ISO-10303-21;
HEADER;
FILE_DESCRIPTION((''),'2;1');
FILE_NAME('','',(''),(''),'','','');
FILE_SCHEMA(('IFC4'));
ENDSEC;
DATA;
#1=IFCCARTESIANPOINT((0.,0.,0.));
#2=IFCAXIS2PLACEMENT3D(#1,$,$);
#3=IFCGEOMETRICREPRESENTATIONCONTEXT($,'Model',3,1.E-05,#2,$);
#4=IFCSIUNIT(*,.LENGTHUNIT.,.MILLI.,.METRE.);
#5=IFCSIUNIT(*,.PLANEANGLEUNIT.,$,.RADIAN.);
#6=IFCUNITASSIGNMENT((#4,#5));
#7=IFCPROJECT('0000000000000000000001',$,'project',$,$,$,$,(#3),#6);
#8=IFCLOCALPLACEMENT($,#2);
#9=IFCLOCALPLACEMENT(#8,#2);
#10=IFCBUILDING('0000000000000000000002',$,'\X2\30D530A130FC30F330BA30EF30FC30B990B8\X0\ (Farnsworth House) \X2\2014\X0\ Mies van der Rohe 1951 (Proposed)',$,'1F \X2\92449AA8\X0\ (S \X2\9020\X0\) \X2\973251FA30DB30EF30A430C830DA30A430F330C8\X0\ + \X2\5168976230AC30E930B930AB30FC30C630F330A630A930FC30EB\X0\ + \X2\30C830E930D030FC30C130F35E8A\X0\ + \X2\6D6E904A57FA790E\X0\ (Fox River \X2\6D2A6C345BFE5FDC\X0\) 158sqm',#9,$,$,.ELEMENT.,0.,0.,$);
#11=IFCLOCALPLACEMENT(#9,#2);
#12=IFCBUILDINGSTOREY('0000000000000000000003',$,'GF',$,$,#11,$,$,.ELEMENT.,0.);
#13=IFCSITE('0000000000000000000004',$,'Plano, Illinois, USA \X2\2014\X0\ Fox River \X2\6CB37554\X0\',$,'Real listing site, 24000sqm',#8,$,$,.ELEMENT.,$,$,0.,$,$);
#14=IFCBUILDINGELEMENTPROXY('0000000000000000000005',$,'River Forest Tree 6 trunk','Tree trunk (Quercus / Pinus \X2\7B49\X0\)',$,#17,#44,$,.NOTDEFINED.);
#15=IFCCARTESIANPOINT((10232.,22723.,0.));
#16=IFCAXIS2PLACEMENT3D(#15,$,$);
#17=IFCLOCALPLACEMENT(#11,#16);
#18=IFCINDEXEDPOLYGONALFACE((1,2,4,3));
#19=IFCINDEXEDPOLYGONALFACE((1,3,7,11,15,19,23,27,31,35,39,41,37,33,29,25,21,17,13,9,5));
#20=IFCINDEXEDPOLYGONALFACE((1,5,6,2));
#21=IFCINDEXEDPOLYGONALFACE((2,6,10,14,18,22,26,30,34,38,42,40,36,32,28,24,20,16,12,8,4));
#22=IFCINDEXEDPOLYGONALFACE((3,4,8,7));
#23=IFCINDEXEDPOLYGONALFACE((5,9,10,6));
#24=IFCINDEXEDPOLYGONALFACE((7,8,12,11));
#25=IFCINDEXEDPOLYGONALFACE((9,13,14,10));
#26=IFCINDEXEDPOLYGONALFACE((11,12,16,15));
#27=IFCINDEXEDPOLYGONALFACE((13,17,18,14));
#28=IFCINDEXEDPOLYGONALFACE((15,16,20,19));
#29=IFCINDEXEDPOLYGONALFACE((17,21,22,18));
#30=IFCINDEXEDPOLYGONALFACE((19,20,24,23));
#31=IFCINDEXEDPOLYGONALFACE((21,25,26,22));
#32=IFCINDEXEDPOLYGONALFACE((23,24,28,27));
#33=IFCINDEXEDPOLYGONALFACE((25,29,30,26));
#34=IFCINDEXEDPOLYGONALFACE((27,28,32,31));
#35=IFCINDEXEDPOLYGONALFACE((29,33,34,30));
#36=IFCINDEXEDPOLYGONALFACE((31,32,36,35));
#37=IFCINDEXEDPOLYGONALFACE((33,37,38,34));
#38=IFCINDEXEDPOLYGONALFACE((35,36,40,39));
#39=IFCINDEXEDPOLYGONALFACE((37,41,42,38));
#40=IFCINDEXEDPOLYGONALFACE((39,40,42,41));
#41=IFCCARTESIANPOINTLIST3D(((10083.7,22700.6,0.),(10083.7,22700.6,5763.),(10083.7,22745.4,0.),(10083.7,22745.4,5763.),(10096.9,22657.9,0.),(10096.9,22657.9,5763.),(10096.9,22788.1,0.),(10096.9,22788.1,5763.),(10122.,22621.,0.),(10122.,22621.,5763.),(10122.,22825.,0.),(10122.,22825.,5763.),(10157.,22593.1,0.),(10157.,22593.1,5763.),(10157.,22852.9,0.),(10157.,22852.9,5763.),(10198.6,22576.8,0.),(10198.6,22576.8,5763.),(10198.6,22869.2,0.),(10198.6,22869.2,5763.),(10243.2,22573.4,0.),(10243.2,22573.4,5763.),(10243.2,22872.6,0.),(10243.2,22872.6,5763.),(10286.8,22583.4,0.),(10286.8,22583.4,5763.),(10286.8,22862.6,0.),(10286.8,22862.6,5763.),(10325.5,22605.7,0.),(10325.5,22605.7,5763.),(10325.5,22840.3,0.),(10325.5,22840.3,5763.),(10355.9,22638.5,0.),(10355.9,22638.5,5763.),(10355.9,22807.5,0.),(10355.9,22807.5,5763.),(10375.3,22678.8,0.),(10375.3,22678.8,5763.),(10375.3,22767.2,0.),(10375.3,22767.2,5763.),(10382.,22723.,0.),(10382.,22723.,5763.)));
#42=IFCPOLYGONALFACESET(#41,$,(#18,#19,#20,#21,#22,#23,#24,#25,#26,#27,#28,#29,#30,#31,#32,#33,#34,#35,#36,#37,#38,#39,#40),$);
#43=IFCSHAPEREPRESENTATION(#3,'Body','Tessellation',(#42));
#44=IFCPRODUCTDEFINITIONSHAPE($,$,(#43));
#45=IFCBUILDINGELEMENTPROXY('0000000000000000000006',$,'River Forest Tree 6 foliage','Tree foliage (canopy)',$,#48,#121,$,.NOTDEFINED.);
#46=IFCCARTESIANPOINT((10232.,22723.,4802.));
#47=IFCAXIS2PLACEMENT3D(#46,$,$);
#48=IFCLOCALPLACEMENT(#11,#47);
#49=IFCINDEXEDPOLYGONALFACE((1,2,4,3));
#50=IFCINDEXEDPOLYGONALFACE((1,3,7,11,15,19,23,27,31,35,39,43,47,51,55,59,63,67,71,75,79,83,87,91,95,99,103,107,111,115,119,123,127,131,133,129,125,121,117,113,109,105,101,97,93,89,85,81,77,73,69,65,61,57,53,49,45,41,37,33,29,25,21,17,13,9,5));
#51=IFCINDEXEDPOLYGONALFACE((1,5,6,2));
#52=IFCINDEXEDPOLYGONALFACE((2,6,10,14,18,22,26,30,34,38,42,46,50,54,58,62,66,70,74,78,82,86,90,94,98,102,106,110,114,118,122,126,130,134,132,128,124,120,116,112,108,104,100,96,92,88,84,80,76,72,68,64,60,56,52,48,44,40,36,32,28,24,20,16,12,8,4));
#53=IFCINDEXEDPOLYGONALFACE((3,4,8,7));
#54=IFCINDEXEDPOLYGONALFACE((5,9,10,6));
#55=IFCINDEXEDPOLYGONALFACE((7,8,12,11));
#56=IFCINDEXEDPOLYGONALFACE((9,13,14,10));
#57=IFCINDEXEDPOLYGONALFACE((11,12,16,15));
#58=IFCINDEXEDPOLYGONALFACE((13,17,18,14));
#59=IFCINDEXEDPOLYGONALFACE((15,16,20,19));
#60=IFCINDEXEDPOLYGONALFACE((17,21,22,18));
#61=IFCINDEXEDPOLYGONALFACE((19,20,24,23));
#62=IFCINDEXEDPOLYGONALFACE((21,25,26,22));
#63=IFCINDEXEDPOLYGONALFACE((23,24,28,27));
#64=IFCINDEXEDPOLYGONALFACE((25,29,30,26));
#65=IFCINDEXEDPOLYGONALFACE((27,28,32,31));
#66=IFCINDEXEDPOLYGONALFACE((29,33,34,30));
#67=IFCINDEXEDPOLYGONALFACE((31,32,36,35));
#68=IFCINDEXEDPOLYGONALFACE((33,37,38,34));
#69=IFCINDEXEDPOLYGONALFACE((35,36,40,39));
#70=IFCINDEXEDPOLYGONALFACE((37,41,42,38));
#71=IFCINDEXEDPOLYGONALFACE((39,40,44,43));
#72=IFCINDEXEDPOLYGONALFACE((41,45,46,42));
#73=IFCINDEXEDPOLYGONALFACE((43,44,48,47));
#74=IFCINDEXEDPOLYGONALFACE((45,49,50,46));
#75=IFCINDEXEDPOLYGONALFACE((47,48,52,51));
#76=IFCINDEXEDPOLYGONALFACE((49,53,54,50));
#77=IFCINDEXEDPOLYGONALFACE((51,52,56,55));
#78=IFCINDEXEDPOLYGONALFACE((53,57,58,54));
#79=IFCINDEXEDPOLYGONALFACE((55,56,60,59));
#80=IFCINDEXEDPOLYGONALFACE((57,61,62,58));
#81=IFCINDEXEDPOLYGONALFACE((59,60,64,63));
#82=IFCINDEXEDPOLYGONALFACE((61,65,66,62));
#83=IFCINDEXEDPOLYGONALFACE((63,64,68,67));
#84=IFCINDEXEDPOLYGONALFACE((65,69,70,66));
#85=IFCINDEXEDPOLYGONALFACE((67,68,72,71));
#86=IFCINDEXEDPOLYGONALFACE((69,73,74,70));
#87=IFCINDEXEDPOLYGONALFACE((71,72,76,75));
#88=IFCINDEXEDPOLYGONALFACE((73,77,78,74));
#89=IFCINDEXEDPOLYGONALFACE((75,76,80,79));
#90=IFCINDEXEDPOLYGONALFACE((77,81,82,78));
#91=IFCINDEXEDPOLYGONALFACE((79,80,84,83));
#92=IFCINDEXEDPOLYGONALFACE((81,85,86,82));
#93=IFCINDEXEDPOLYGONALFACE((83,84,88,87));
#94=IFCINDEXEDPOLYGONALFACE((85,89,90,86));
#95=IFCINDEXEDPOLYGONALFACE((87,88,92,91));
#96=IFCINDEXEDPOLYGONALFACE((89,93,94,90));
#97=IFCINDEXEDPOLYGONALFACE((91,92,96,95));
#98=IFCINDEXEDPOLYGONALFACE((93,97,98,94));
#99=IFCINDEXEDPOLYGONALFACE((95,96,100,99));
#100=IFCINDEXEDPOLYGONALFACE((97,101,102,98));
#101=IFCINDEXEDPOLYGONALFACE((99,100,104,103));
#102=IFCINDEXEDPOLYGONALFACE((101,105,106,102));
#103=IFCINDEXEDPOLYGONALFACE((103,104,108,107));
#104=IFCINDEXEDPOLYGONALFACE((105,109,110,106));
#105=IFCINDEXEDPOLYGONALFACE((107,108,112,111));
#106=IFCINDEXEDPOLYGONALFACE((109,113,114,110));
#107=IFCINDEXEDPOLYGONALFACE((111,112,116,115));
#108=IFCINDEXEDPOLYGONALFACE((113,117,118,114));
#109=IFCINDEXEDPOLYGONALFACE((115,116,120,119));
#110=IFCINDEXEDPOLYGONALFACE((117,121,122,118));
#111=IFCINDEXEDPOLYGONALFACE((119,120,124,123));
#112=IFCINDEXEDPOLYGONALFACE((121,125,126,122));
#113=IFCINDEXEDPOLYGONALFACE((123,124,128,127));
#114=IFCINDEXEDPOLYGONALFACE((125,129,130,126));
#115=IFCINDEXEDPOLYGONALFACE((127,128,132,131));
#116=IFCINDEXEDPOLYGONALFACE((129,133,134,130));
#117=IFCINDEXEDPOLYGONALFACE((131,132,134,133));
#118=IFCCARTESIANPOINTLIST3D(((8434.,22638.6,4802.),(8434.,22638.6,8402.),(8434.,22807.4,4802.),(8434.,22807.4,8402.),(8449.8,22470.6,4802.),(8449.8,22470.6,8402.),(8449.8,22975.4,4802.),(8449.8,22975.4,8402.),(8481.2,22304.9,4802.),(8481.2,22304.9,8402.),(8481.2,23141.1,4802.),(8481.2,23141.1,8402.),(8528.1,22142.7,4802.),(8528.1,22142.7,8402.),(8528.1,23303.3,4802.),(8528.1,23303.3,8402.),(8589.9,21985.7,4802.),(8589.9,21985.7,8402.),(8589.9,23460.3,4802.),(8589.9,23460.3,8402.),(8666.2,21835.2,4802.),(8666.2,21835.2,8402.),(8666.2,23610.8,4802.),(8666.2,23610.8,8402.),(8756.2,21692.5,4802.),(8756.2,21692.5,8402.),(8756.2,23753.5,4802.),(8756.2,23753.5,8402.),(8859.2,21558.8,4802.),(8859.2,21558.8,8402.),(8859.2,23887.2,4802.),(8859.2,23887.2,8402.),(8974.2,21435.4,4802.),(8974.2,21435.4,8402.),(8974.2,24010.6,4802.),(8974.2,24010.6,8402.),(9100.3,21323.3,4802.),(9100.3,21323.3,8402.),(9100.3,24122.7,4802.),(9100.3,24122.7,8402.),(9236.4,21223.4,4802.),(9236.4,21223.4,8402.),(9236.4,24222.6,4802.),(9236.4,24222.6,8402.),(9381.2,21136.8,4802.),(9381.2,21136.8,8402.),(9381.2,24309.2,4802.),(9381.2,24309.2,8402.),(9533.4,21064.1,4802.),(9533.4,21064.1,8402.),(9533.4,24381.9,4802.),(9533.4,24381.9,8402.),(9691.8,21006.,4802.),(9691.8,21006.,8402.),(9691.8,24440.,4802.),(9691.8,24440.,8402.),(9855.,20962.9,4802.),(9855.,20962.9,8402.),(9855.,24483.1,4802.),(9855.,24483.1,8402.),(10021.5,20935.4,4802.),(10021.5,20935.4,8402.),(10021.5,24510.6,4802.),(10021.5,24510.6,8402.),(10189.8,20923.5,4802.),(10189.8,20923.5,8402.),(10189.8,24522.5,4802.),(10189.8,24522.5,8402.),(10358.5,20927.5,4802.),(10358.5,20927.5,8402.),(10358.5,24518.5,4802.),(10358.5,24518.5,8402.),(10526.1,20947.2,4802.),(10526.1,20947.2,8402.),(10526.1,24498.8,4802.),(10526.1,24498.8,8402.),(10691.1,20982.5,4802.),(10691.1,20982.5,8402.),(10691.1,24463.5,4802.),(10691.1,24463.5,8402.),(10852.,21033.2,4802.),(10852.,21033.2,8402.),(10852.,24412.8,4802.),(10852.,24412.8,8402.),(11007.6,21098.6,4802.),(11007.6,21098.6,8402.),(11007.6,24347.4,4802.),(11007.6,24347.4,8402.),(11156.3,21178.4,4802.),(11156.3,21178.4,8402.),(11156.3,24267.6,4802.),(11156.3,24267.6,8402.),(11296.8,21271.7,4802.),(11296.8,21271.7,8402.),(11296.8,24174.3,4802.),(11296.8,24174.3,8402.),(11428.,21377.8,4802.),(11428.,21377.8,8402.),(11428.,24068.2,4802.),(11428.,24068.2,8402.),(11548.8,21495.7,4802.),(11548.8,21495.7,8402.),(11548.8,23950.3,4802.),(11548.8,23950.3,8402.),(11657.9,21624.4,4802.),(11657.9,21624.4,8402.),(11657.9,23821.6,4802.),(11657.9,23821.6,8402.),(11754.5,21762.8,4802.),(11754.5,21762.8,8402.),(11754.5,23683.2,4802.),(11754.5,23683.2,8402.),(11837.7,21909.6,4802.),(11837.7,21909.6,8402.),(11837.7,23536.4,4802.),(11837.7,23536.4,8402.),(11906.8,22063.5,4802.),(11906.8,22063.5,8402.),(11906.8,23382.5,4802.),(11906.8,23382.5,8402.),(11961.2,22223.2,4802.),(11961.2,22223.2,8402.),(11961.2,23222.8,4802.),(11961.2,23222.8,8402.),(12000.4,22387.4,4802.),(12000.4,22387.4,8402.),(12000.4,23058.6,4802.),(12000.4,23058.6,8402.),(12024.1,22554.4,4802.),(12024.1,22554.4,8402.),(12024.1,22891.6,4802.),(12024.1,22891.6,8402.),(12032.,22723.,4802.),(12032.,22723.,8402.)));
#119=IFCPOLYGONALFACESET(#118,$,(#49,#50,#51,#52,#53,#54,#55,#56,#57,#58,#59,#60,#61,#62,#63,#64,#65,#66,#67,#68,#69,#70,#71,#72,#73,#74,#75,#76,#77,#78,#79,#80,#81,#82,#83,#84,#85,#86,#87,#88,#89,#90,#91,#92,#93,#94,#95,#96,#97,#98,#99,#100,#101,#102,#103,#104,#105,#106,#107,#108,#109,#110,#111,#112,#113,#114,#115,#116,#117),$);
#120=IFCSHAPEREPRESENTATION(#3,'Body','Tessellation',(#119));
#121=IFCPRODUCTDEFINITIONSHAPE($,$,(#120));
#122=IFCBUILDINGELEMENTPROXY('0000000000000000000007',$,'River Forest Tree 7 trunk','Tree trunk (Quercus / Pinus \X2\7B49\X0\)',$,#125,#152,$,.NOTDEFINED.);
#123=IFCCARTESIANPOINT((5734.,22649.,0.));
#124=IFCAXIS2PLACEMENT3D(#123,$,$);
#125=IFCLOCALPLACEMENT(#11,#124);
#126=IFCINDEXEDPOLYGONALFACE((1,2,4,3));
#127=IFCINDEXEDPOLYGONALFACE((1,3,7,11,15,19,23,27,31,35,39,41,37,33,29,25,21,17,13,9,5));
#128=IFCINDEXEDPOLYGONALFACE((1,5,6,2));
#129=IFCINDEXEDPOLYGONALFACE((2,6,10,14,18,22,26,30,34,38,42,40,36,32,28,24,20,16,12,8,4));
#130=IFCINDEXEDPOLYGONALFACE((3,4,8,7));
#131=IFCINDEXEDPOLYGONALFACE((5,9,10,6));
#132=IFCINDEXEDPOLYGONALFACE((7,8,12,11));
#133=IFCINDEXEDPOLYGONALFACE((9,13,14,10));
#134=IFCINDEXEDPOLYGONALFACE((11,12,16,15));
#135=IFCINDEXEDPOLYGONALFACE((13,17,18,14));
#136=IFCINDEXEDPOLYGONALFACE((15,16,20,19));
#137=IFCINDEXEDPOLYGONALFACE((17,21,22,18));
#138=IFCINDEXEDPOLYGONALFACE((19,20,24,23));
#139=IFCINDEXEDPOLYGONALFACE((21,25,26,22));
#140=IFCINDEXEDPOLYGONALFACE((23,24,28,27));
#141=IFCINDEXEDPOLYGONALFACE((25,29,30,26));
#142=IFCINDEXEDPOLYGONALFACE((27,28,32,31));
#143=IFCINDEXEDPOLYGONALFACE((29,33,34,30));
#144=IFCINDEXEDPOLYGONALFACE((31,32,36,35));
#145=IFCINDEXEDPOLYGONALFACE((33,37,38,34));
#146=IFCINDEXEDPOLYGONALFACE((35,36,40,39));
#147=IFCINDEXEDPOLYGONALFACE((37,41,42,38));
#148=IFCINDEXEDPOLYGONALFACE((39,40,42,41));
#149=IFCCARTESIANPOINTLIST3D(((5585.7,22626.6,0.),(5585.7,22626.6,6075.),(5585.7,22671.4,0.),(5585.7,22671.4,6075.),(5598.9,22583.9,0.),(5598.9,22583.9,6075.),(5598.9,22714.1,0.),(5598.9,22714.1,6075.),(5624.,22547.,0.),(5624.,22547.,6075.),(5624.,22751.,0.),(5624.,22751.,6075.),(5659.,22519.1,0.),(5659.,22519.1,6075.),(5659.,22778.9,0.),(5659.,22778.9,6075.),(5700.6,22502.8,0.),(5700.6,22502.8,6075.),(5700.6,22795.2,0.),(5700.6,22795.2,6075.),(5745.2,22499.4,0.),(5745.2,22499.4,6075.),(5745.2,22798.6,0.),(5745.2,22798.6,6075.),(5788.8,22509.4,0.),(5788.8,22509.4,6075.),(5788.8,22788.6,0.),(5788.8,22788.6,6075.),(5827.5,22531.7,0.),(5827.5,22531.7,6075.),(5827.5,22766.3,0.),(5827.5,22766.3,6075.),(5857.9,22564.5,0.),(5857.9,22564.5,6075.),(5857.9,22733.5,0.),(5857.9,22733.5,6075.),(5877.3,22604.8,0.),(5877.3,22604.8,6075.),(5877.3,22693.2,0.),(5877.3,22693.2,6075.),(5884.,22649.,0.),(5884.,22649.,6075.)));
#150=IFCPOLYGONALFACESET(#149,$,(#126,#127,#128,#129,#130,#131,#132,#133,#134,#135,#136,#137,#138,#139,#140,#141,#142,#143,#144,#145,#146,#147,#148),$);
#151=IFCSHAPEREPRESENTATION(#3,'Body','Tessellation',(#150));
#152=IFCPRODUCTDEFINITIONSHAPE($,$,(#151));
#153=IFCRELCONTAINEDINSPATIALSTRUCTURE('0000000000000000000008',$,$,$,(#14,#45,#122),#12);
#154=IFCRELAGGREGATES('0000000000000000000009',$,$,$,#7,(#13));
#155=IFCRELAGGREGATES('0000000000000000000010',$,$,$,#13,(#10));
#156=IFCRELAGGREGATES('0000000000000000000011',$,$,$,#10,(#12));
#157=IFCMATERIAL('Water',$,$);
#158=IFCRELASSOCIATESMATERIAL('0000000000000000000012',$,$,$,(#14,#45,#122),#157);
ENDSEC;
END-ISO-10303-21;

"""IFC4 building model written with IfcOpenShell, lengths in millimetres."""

from ifc_helpers import new_model, si_unit, frame, origin, origin_2d, place, context, project, spatial, circle, extrude, material, element, save


model = new_model("IFC4")

# Units and contexts
model_context = context("Model", 3, precision=1e-05, world=origin())
ifc_project = project(units=[si_unit("LENGTHUNIT", "METRE", prefix="MILLI"), si_unit("PLANEANGLEUNIT", "RADIAN")], contexts=[model_context])

# Site, building, storey
site_placement = place(None, origin())
site = spatial("IfcSite", under=ifc_project, at=site_placement, Name="Plano, Illinois, USA — Fox River 河畔", ObjectType="Real listing site, 24000sqm", CompositionType="ELEMENT", RefElevation=0.0)
building_placement = place(site_placement, origin())
building = spatial("IfcBuilding", under=site, at=building_placement, Name="ファーンズワース邸 (Farnsworth House) — Mies van der Rohe 1951 (Proposed)", ObjectType="1F 鉄骨 (S 造) 露出ホワイトペイント + 全面ガラスカーテンウォール + トラバーチン床 + 浮遊基礎 (Fox River 洪水対応) 158sqm", CompositionType="ELEMENT", ElevationOfRefHeight=0.0, ElevationOfTerrain=0.0)
storey_placement = place(building_placement, origin())
storey = spatial("IfcBuildingStorey", under=building, at=storey_placement, Name="GF", CompositionType="ELEMENT", Elevation=0.0)

# Building element proxies
ifc_material_1 = material(Name="Water")
proxy_1_placement = place(storey_placement, frame((10232.0, 22723.0, 0.0)))
element("IfcBuildingElementProxy", 1, at=proxy_1_placement, inside=storey, material=ifc_material_1, Name="River Forest Tree 6 trunk", Description="Tree trunk (Quercus / Pinus 等)", PredefinedType="NOTDEFINED", context=model_context, shape_type="SweptSolid", body=[
    extrude(circle(Radius=150.0, at=origin_2d()), frame((10232.0, 22723.0, 0.0)), (0.0, 0.0, 1.0), 5763.0),
])
proxy_2_placement = place(storey_placement, frame((10232.0, 22723.0, 4802.0)))
element("IfcBuildingElementProxy", 2, at=proxy_2_placement, inside=storey, material=ifc_material_1, Name="River Forest Tree 6 foliage", Description="Tree foliage (canopy)", PredefinedType="NOTDEFINED", context=model_context, shape_type="SweptSolid", body=[
    extrude(circle(Radius=1800.0, at=origin_2d()), frame((10232.0, 22723.0, 4802.0)), (0.0, 0.0, 1.0), 3600.0),
])
proxy_3_placement = place(storey_placement, frame((5734.0, 22649.0, 0.0)))
element("IfcBuildingElementProxy", 3, at=proxy_3_placement, inside=storey, material=ifc_material_1, Name="River Forest Tree 7 trunk", Description="Tree trunk (Quercus / Pinus 等)", PredefinedType="NOTDEFINED", context=model_context, shape_type="SweptSolid", body=[
    extrude(circle(Radius=150.0, at=origin_2d()), frame((5734.0, 22649.0, 0.0)), (0.0, 0.0, 1.0), 6075.0),
])

save(model, "model.ifc")
